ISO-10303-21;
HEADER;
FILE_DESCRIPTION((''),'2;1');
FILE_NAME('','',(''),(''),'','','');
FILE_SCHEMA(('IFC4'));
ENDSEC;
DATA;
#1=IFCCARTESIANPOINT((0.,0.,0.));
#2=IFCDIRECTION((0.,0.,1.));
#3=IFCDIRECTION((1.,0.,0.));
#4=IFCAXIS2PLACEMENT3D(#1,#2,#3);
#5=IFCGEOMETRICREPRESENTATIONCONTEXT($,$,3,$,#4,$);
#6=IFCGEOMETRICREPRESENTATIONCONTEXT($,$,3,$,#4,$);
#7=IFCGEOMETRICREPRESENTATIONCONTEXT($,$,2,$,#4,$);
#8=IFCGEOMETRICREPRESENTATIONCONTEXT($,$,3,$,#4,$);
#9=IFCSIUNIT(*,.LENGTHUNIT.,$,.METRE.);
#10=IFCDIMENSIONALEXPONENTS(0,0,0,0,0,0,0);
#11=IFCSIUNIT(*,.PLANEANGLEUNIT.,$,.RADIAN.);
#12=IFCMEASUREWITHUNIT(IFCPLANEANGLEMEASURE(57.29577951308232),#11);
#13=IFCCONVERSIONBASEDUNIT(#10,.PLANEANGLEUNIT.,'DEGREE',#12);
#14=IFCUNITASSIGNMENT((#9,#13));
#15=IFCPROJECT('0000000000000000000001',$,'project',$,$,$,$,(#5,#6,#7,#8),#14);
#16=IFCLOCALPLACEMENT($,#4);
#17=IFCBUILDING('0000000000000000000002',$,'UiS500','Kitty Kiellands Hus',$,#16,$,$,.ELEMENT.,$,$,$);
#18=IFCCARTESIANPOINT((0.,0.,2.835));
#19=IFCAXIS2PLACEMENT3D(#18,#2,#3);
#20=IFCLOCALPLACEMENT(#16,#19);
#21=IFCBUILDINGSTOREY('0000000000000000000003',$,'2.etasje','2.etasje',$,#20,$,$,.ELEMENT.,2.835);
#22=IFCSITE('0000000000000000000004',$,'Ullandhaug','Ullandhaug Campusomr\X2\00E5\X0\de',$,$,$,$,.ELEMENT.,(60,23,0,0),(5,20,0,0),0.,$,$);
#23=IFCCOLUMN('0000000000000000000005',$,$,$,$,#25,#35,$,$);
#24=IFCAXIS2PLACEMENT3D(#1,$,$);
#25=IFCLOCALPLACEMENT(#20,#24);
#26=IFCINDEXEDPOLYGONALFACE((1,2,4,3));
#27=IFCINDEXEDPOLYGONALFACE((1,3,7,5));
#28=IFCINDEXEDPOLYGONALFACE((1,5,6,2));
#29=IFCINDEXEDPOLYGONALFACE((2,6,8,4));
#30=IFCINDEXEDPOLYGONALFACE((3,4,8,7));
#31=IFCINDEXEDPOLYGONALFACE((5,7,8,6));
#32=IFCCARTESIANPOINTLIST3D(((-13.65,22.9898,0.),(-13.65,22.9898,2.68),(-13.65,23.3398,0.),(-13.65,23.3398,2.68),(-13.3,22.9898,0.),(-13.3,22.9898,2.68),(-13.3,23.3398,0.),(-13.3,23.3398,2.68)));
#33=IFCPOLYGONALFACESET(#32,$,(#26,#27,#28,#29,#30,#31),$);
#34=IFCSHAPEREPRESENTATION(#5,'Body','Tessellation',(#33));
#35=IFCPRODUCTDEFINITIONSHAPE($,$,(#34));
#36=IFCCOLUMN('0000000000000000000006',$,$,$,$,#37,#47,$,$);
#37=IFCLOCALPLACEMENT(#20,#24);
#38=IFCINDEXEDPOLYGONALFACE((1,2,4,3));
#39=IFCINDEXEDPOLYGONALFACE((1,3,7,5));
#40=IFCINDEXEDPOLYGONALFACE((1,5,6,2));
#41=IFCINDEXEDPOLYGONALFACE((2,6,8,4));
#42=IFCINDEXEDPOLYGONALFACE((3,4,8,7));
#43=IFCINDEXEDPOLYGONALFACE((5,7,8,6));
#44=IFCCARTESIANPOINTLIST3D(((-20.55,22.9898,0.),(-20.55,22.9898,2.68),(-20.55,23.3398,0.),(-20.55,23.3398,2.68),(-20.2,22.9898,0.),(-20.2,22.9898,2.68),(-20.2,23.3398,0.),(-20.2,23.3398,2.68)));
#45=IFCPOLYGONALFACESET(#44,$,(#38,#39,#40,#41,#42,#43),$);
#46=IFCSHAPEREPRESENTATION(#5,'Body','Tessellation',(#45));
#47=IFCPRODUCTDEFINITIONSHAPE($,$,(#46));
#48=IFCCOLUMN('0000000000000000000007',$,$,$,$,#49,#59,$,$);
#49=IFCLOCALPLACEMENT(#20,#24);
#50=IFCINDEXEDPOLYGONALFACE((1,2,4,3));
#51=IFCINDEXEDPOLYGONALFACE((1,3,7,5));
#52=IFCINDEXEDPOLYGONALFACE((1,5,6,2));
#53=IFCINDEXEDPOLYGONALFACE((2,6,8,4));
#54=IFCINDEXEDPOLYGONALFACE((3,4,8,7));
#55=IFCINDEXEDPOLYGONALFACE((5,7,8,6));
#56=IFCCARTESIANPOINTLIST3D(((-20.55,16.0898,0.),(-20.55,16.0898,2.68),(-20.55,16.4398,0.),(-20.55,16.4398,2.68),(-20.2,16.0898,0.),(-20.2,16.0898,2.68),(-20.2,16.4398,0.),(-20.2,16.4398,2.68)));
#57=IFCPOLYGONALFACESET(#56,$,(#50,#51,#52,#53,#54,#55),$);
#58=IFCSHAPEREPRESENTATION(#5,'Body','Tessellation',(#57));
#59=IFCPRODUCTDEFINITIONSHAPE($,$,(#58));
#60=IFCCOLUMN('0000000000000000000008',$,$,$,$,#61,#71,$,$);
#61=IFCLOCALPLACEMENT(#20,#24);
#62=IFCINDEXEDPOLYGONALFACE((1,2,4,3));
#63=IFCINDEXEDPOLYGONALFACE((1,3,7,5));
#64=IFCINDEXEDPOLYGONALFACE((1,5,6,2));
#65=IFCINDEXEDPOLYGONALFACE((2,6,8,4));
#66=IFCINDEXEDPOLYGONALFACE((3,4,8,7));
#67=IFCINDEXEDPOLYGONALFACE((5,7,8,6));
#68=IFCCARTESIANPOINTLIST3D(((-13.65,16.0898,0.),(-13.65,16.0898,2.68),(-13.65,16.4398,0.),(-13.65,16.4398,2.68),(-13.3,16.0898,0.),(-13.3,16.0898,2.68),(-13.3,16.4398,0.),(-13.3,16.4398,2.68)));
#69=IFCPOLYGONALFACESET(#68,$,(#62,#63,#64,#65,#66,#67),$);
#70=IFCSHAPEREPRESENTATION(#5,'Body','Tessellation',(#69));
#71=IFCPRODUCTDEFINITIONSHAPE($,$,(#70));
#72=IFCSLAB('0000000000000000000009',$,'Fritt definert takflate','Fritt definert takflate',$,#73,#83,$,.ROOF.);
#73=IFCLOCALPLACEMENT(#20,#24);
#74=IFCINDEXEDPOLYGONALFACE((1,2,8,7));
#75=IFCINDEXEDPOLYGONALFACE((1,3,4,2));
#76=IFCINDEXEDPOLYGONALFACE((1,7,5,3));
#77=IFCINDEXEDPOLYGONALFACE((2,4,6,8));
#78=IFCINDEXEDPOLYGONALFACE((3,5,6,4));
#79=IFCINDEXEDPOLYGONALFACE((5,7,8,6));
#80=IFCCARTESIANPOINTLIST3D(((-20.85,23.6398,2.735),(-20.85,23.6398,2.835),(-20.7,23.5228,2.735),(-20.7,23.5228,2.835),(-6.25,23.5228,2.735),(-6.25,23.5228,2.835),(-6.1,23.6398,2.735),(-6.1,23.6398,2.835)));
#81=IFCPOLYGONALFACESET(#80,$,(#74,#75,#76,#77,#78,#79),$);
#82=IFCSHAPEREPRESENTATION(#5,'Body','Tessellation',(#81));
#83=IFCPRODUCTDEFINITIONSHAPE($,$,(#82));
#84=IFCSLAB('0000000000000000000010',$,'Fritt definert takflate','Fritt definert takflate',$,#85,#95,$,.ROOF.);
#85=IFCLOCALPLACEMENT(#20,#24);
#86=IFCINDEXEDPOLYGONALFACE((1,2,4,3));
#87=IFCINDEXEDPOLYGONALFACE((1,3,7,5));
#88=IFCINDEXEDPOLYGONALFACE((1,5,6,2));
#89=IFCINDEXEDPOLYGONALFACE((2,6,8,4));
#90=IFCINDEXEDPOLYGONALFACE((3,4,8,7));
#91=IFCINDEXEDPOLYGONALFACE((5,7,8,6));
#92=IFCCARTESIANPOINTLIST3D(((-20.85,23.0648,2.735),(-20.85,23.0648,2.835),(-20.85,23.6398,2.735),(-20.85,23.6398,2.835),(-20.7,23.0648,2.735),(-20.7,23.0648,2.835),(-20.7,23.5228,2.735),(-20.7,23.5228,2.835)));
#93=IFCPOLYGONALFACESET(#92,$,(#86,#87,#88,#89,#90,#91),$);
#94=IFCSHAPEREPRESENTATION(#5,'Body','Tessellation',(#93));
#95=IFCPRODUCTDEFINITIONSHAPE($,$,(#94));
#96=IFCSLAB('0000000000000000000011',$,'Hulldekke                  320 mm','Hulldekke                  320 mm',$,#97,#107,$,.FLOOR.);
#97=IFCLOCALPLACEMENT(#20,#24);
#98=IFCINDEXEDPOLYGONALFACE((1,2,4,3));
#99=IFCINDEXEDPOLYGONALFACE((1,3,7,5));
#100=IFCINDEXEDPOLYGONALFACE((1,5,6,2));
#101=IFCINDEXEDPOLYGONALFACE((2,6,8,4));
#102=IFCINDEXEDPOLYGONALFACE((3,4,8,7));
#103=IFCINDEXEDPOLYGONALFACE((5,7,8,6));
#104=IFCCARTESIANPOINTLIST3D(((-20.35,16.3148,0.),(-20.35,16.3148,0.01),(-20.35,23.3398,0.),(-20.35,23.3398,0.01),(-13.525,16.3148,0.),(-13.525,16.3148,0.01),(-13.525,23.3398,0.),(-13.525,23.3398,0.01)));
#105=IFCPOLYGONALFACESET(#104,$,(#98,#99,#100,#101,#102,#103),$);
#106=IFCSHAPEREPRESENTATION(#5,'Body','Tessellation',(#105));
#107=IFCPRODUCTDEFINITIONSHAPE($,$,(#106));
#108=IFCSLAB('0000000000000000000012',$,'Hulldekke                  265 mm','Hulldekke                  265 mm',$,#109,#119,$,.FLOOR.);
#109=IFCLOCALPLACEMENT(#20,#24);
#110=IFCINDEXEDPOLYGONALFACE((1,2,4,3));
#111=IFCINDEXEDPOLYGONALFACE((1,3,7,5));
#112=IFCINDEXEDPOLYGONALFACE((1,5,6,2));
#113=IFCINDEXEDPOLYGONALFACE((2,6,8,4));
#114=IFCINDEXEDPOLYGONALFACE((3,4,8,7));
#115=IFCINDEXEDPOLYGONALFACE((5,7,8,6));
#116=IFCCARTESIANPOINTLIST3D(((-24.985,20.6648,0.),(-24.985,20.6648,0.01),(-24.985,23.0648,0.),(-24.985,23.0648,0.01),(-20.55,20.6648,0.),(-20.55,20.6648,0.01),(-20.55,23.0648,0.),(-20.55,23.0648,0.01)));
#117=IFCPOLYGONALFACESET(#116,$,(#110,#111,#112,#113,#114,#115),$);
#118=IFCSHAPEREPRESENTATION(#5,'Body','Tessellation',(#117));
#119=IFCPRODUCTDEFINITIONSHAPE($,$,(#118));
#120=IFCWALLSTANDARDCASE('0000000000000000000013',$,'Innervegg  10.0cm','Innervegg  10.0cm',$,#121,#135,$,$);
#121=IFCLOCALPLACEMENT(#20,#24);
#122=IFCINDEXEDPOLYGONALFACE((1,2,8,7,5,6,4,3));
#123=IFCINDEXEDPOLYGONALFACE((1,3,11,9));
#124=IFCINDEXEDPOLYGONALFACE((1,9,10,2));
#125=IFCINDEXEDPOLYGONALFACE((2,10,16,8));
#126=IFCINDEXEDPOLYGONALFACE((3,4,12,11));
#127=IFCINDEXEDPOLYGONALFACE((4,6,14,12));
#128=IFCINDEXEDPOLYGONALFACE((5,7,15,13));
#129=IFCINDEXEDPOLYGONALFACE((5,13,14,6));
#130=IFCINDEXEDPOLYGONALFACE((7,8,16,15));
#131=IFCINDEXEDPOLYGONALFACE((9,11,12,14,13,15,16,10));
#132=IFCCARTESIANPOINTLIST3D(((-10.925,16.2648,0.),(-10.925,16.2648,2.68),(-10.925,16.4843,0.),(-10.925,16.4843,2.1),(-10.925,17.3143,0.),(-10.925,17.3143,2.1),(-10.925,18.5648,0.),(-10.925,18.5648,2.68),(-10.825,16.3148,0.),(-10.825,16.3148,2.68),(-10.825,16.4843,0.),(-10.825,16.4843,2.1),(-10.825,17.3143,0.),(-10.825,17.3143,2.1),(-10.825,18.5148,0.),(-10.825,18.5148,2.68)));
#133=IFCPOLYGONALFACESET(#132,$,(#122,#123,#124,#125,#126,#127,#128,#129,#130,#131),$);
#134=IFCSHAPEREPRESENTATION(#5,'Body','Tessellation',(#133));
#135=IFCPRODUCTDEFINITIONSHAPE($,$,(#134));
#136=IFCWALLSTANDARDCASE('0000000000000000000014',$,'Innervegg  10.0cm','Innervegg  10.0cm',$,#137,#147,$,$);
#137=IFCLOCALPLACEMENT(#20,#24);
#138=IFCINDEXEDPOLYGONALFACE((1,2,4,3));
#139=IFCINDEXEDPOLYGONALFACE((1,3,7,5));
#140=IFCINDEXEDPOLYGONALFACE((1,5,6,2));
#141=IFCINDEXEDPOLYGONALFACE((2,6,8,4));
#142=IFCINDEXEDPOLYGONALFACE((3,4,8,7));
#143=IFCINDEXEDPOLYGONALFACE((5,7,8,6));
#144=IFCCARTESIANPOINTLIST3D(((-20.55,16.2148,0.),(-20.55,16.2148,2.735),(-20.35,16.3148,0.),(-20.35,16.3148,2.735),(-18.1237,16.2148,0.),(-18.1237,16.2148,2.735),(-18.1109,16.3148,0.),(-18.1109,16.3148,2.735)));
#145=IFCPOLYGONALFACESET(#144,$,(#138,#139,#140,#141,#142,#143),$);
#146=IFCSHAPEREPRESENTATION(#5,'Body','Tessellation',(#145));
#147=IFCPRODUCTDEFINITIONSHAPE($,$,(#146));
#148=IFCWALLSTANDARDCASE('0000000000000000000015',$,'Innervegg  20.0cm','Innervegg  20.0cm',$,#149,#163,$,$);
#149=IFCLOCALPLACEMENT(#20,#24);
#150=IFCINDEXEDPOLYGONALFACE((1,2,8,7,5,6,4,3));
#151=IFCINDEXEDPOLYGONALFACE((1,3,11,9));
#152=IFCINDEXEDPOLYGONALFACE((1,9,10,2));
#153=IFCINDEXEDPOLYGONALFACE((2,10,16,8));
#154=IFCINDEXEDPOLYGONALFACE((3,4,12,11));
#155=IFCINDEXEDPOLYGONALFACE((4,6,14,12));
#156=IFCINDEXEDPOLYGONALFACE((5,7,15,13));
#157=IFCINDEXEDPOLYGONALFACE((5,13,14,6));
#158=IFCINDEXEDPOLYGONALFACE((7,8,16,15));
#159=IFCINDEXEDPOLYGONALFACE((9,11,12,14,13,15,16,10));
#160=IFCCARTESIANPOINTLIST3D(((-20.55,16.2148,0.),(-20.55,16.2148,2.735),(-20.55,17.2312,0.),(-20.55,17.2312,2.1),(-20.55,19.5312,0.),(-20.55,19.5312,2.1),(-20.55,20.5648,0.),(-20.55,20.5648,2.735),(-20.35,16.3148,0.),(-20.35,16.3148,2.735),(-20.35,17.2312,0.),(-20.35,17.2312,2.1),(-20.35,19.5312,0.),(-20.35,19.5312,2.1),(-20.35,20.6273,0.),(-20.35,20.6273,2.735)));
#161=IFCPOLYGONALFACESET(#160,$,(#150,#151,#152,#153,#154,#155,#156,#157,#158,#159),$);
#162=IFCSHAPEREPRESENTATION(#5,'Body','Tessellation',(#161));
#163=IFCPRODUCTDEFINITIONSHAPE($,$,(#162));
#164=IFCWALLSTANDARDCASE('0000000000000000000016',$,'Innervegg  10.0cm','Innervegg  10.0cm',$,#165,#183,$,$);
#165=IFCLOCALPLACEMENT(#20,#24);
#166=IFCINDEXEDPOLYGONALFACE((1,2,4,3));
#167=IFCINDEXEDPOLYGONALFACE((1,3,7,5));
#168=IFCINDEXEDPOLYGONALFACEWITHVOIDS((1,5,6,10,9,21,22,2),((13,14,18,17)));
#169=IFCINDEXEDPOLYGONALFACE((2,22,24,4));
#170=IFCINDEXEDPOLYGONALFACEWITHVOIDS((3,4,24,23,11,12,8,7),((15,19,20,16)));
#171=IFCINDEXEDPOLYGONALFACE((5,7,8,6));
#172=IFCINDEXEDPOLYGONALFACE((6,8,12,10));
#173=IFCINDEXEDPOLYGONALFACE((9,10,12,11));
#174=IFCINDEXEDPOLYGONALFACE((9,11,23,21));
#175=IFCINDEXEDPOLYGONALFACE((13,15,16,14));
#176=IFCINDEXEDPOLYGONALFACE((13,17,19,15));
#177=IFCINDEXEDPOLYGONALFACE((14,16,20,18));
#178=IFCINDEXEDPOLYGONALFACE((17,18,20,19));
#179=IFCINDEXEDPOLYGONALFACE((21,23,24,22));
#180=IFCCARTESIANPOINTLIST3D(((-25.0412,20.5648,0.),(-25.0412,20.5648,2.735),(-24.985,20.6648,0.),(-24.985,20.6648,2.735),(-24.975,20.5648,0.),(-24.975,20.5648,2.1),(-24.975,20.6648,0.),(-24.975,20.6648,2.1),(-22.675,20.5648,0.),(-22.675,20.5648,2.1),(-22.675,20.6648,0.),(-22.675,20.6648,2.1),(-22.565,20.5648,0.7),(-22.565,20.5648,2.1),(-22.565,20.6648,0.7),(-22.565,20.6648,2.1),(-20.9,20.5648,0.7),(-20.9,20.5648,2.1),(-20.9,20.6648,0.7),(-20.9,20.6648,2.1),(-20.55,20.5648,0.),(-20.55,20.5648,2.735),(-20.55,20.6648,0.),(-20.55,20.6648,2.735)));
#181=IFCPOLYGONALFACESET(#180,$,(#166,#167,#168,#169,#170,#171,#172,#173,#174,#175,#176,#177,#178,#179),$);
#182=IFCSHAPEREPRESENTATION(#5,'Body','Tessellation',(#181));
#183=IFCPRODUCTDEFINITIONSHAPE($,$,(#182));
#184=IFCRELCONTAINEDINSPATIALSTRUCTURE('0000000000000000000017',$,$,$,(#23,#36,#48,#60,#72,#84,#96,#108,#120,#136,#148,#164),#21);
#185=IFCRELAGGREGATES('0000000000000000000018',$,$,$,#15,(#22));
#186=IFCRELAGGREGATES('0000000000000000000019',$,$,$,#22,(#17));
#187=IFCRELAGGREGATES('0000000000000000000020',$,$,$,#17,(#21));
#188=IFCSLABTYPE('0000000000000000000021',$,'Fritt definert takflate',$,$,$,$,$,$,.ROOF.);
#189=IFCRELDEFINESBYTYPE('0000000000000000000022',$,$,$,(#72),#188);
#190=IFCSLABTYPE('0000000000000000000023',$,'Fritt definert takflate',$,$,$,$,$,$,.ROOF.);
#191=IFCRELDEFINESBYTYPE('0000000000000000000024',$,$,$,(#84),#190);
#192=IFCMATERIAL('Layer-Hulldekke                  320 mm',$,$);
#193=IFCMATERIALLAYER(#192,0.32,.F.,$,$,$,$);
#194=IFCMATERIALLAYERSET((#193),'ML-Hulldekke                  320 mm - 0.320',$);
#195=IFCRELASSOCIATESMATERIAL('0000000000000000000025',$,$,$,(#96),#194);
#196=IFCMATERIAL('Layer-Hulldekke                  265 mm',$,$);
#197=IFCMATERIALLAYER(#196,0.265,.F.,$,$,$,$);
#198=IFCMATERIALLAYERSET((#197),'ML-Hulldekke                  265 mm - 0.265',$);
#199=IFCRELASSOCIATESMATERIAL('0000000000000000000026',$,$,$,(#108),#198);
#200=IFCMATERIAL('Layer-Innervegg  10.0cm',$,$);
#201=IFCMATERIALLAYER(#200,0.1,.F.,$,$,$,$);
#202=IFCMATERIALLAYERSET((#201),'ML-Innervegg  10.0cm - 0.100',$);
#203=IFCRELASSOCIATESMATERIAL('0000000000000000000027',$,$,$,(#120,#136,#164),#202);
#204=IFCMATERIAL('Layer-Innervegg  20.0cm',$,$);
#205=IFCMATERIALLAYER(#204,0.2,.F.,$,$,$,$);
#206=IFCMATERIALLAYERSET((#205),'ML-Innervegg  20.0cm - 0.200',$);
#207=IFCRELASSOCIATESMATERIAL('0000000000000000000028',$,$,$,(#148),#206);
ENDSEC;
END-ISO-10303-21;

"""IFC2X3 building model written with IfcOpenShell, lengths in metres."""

from ifc_helpers import new_model, entity, si_unit, converted_unit, frame, origin_with_axes, origin_2d_with_axis, place, context, project, spatial, polyline, rectangle, outline, extrude, material, layer, layer_set, layer_usage, type_object, element, save


model = new_model("IFC2X3")

# Units and contexts
context_of_model_1 = context(None, 3, world=origin_with_axes())
context_of_model_2 = context(None, 3, world=origin_with_axes())
context_of_model_3 = context(None, 2, world=origin_with_axes())
context_of_model_4 = context(None, 3, world=origin_with_axes())
ifc_project = project(units=[si_unit("LENGTHUNIT", "METRE"), converted_unit("PLANEANGLEUNIT", "DEGREE", entity("IfcPlaneAngleMeasure", 57.29577951308232), si_unit("PLANEANGLEUNIT", "RADIAN"), dimensions=[0, 0, 0, 0, 0, 0, 0])], contexts=[context_of_model_1, context_of_model_2, context_of_model_3, context_of_model_4])

# Site, building, storey
site = spatial("IfcSite", under=ifc_project, Name="Ullandhaug", Description="Ullandhaug Campusområde", CompositionType="ELEMENT", RefLatitude=(60, 23, 0, 0), RefLongitude=(5, 20, 0, 0), RefElevation=0.0)
building_placement = place(None, origin_with_axes())
building = spatial("IfcBuilding", under=site, at=building_placement, Name="UiS500", Description="Kitty Kiellands Hus", CompositionType="ELEMENT")
storey_placement = place(building_placement, frame((0.0, 0.0, 2.835), z_axis=(0.0, 0.0, 1.0), x_axis=(1.0, 0.0, 0.0)))
storey = spatial("IfcBuildingStorey", under=building, at=storey_placement, Name="2.etasje", Description="2.etasje", CompositionType="ELEMENT", Elevation=2.835)

# Columns
for number, where, z_axis, x_axis in (
    (1, (-13.475, 23.1648, 0.0), (0.0, 0.0, 1.0), (1.0, 0.0, 0.0)),
    (2, (-20.375, 23.1648, 0.0), (0.0, 0.0, 1.0), (1.0, 0.0, 0.0)),
    (3, (-20.375, 16.2648, 0.0), (0.0, 0.0, 1.0), (1.0, 0.0, 0.0)),
    (4, (-13.475, 16.2648, 0.0), (0.0, 0.0, 1.0), (1.0, 0.0, 0.0)),
):
    element("IfcColumn", number, at=place(storey_placement, frame(where, z_axis=z_axis, x_axis=x_axis)), inside=storey, context=context_of_model_1, shape_type="SweptSolid", body=[
        extrude(rectangle(XDim=0.35, YDim=0.35, at=origin_2d_with_axis()), origin_with_axes(), (0.0, 0.0, 1.0), 2.68),
    ])

# Slabs
slab_type_1 = type_object("IfcSlabType", Name="Fritt definert takflate", PredefinedType="ROOF")
slab_1_placement = place(storey_placement, frame((-20.85, 23.6398, 2.735), z_axis=(0.0, 0.0, 1.0), x_axis=(0.7885, -0.615035, 0.0)))
element("IfcSlab", 5, at=slab_1_placement, inside=storey, type_object=slab_type_1, Name="Fritt definert takflate", Description="Fritt definert takflate", PredefinedType="ROOF", context=context_of_model_1, shape_type="SweptSolid", body=[
    extrude(outline(polyline([(0.0, 0.0), (0.1902, 0.0), (11.5841, 8.8873), (11.6304, 9.0718), (0.0, 0.0)])), origin_with_axes(), (0.0, 0.0, 1.0), 0.1),
])
slab_type_2 = type_object("IfcSlabType", Name="Fritt definert takflate", PredefinedType="ROOF")
slab_2_placement = place(storey_placement, frame((-20.7, 23.5228, 2.735), z_axis=(0.0, 0.0, 1.0), x_axis=(-0.7885, 0.615035, 0.0)))
element("IfcSlab", 6, at=slab_2_placement, inside=storey, type_object=slab_type_2, Name="Fritt definert takflate", Description="Fritt definert takflate", PredefinedType="ROOF", context=context_of_model_1, shape_type="SweptSolid", body=[
    extrude(outline(polyline([(0.0, 0.0), (0.1902, 0.0), (-0.1634, 0.4534), (-0.2817, 0.3611), (0.0, 0.0)])), origin_with_axes(), (0.0, 0.0, 1.0), 0.1),
])
ifc_material_1 = material(Name="Layer-Hulldekke                  320 mm")
ifc_layer_1 = layer(ifc_material_1, 0.32, ventilated=False)
ifc_layer_set_1 = layer_set([ifc_layer_1], Name="ML-Hulldekke                  320 mm - 0.320")
ifc_layer_usage_1 = layer_usage(ifc_layer_set_1, "AXIS2", "POSITIVE", 0.0)
slab_3_placement = place(storey_placement, frame((-13.525, 16.3148, 0.0), z_axis=(0.0, 0.0, 1.0), x_axis=(1.0, 0.0, 0.0)))
element("IfcSlab", 7, at=slab_3_placement, inside=storey, material=ifc_layer_usage_1, Name="Hulldekke                  320 mm", Description="Hulldekke                  320 mm", PredefinedType="FLOOR", context=context_of_model_1, shape_type="SweptSolid", body=[
    extrude(outline(polyline([(0.0, 0.0), (7.025, 0.0), (7.025, 6.825), (0.0, 6.825), (0.0, 0.0)])), frame((0.0, 0.0, 0.0), z_axis=(0.0, 0.0, 1.0), x_axis=(0.0, 1.0, 0.0)), (0.0, 0.0, 1.0), 0.01),
])
ifc_material_2 = material(Name="Layer-Hulldekke                  265 mm")
ifc_layer_2 = layer(ifc_material_2, 0.265, ventilated=False)
ifc_layer_set_2 = layer_set([ifc_layer_2], Name="ML-Hulldekke                  265 mm - 0.265")
ifc_layer_usage_2 = layer_usage(ifc_layer_set_2, "AXIS2", "POSITIVE", 0.0)
slab_4_placement = place(storey_placement, frame((-20.55, 23.0648, 0.0), z_axis=(0.0, 0.0, 1.0), x_axis=(1.0, 0.0, 0.0)))
element("IfcSlab", 8, at=slab_4_placement, inside=storey, material=ifc_layer_usage_2, Name="Hulldekke                  265 mm", Description="Hulldekke                  265 mm", PredefinedType="FLOOR", context=context_of_model_1, shape_type="SweptSolid", body=[
    extrude(outline(polyline([(0.0, 0.0), (4.435, 0.0), (4.435, 2.4), (0.0, 2.4), (0.0, 0.0)])), frame((0.0, 0.0, 0.0), z_axis=(0.0, 0.0, 1.0), x_axis=(-1.0, 0.0, 0.0)), (0.0, 0.0, 1.0), 0.01),
])

# Wall, opening
ifc_material_3 = material(Name="Layer-Innervegg  10.0cm")
ifc_layer_3 = layer(ifc_material_3, 0.1, ventilated=False)
ifc_layer_set_3 = layer_set([ifc_layer_3], Name="ML-Innervegg  10.0cm - 0.100")
ifc_layer_usage_3 = layer_usage(ifc_layer_set_3, "AXIS2", "POSITIVE", 0.0)
wall_1_placement = place(storey_placement, frame((-10.925, 18.5648, 0.0), z_axis=(0.0, 0.0, 1.0), x_axis=(0.0, -1.0, 0.0)))
wall_1 = element("IfcWallStandardCase", 9, at=wall_1_placement, inside=storey, material=ifc_layer_usage_3, Name="Innervegg  10.0cm", Description="Innervegg  10.0cm", context=context_of_model_1, shape_type="SweptSolid", body=[
    extrude(outline(polyline([(0.0, 0.0), (2.3, 0.0), (2.25, 0.1), (0.05, 0.1), (0.0, 0.0)])), frame((0.0, 0.0, 0.0), z_axis=(0.0, 0.0, 1.0), x_axis=(1.0, 0.0, 0.0)), (0.0, 0.0, 1.0), 2.68),
])
opening_1_placement = place(wall_1_placement, frame((1.2504, 0.1, 0.0), z_axis=(0.0, 0.0, 1.0), x_axis=(1.0, 0.0, 0.0)))
element("IfcOpeningElement", 10, at=opening_1_placement, cuts=wall_1, context=context_of_model_1, shape_type="SweptSolid", body=[
    extrude(outline(polyline([(0.0, 0.0), (2.1, 0.0), (2.1, 0.83), (0.0, 0.83), (0.0, 0.0)])), frame((0.0, 0.0, 0.0), z_axis=(0.0, 1.0, 0.0), x_axis=(0.0, 0.0, 1.0)), (0.0, 0.0, -1.0), 0.1),
])

# Wall
wall_2_placement = place(storey_placement, frame((-18.1109, 16.3148, 0.0), z_axis=(0.0, 0.0, 1.0), x_axis=(-1.0, 0.0, 0.0)))
element("IfcWallStandardCase", 11, at=wall_2_placement, inside=storey, material=ifc_layer_usage_3, Name="Innervegg  10.0cm", Description="Innervegg  10.0cm", context=context_of_model_1, shape_type="SweptSolid", body=[
    extrude(outline(polyline([(0.0, 0.0), (2.2391, 0.0), (2.4391, 0.1), (0.0127, 0.1), (0.0, 0.0)])), frame((0.0, 0.0, 0.0), z_axis=(0.0, 0.0, 1.0), x_axis=(1.0, 0.0, 0.0)), (0.0, 0.0, 1.0), 2.735),
])

# Wall, opening
ifc_material_4 = material(Name="Layer-Innervegg  20.0cm")
ifc_layer_4 = layer(ifc_material_4, 0.2, ventilated=False)
ifc_layer_set_4 = layer_set([ifc_layer_4], Name="ML-Innervegg  20.0cm - 0.200")
ifc_layer_usage_4 = layer_usage(ifc_layer_set_4, "AXIS2", "POSITIVE", 0.0)
wall_3_placement = place(storey_placement, frame((-20.35, 16.3148, 0.0), z_axis=(0.0, 0.0, 1.0), x_axis=(0.0, 1.0, 0.0)))
wall_3 = element("IfcWallStandardCase", 12, at=wall_3_placement, inside=storey, material=ifc_layer_usage_4, Name="Innervegg  20.0cm", Description="Innervegg  20.0cm", context=context_of_model_1, shape_type="SweptSolid", body=[
    extrude(outline(polyline([(0.0, 0.0), (4.3125, 0.0), (4.25, 0.2), (-0.1, 0.2), (0.0, 0.0)])), frame((0.0, 0.0, 0.0), z_axis=(0.0, 0.0, 1.0), x_axis=(1.0, 0.0, 0.0)), (0.0, 0.0, 1.0), 2.735),
])
opening_2_placement = place(wall_3_placement, frame((0.9164, 0.2, 0.0), z_axis=(0.0, 0.0, 1.0), x_axis=(1.0, 0.0, 0.0)))
element("IfcOpeningElement", 13, at=opening_2_placement, cuts=wall_3, context=context_of_model_1, shape_type="SweptSolid", body=[
    extrude(outline(polyline([(0.0, 0.0), (2.1, 0.0), (2.1, 2.3), (0.0, 2.3), (0.0, 0.0)])), frame((0.0, 0.0, 0.0), z_axis=(0.0, 1.0, 0.0), x_axis=(0.0, 0.0, 1.0)), (0.0, 0.0, -1.0), 0.2),
])

# Wall, openings
wall_4_placement = place(storey_placement, frame((-20.55, 20.6648, 0.0), z_axis=(0.0, 0.0, 1.0), x_axis=(-1.0, 0.0, 0.0)))
wall_4 = element("IfcWallStandardCase", 14, at=wall_4_placement, inside=storey, material=ifc_layer_usage_3, Name="Innervegg  10.0cm", Description="Innervegg  10.0cm", context=context_of_model_1, shape_type="SweptSolid", body=[
    extrude(outline(polyline([(0.0, 0.0), (4.435, 0.0), (4.4912, 0.1), (0.0, 0.1), (0.0, 0.0)])), frame((0.0, 0.0, 0.0), z_axis=(0.0, 0.0, 1.0), x_axis=(1.0, 0.0, 0.0)), (0.0, 0.0, 1.0), 2.735),
])
opening_3_placement = place(wall_4_placement, frame((2.125, 0.1, 0.0), z_axis=(0.0, 0.0, 1.0), x_axis=(1.0, 0.0, 0.0)))
element("IfcOpeningElement", 15, at=opening_3_placement, cuts=wall_4, context=context_of_model_1, shape_type="SweptSolid", body=[
    extrude(outline(polyline([(0.0, 0.0), (2.1, 0.0), (2.1, 2.3), (0.0, 2.3), (0.0, 0.0)])), frame((0.0, 0.0, 0.0), z_axis=(0.0, 1.0, 0.0), x_axis=(0.0, 0.0, 1.0)), (0.0, 0.0, -1.0), 0.1),
])
opening_4_placement = place(wall_4_placement, frame((0.35, 0.1, 0.7), z_axis=(0.0, 0.0, 1.0), x_axis=(1.0, 0.0, 0.0)))
element("IfcOpeningElement", 16, at=opening_4_placement, cuts=wall_4, context=context_of_model_1, shape_type="SweptSolid", body=[
    extrude(outline(polyline([(0.0, 0.0), (1.4, 0.0), (1.4, 1.665), (0.0, 1.665), (0.0, 0.0)])), frame((0.0, 0.0, 0.0), z_axis=(0.0, 1.0, 0.0), x_axis=(0.0, 0.0, 1.0)), (0.0, 0.0, -1.0), 0.1),
])

save(model, "model.ifc")
